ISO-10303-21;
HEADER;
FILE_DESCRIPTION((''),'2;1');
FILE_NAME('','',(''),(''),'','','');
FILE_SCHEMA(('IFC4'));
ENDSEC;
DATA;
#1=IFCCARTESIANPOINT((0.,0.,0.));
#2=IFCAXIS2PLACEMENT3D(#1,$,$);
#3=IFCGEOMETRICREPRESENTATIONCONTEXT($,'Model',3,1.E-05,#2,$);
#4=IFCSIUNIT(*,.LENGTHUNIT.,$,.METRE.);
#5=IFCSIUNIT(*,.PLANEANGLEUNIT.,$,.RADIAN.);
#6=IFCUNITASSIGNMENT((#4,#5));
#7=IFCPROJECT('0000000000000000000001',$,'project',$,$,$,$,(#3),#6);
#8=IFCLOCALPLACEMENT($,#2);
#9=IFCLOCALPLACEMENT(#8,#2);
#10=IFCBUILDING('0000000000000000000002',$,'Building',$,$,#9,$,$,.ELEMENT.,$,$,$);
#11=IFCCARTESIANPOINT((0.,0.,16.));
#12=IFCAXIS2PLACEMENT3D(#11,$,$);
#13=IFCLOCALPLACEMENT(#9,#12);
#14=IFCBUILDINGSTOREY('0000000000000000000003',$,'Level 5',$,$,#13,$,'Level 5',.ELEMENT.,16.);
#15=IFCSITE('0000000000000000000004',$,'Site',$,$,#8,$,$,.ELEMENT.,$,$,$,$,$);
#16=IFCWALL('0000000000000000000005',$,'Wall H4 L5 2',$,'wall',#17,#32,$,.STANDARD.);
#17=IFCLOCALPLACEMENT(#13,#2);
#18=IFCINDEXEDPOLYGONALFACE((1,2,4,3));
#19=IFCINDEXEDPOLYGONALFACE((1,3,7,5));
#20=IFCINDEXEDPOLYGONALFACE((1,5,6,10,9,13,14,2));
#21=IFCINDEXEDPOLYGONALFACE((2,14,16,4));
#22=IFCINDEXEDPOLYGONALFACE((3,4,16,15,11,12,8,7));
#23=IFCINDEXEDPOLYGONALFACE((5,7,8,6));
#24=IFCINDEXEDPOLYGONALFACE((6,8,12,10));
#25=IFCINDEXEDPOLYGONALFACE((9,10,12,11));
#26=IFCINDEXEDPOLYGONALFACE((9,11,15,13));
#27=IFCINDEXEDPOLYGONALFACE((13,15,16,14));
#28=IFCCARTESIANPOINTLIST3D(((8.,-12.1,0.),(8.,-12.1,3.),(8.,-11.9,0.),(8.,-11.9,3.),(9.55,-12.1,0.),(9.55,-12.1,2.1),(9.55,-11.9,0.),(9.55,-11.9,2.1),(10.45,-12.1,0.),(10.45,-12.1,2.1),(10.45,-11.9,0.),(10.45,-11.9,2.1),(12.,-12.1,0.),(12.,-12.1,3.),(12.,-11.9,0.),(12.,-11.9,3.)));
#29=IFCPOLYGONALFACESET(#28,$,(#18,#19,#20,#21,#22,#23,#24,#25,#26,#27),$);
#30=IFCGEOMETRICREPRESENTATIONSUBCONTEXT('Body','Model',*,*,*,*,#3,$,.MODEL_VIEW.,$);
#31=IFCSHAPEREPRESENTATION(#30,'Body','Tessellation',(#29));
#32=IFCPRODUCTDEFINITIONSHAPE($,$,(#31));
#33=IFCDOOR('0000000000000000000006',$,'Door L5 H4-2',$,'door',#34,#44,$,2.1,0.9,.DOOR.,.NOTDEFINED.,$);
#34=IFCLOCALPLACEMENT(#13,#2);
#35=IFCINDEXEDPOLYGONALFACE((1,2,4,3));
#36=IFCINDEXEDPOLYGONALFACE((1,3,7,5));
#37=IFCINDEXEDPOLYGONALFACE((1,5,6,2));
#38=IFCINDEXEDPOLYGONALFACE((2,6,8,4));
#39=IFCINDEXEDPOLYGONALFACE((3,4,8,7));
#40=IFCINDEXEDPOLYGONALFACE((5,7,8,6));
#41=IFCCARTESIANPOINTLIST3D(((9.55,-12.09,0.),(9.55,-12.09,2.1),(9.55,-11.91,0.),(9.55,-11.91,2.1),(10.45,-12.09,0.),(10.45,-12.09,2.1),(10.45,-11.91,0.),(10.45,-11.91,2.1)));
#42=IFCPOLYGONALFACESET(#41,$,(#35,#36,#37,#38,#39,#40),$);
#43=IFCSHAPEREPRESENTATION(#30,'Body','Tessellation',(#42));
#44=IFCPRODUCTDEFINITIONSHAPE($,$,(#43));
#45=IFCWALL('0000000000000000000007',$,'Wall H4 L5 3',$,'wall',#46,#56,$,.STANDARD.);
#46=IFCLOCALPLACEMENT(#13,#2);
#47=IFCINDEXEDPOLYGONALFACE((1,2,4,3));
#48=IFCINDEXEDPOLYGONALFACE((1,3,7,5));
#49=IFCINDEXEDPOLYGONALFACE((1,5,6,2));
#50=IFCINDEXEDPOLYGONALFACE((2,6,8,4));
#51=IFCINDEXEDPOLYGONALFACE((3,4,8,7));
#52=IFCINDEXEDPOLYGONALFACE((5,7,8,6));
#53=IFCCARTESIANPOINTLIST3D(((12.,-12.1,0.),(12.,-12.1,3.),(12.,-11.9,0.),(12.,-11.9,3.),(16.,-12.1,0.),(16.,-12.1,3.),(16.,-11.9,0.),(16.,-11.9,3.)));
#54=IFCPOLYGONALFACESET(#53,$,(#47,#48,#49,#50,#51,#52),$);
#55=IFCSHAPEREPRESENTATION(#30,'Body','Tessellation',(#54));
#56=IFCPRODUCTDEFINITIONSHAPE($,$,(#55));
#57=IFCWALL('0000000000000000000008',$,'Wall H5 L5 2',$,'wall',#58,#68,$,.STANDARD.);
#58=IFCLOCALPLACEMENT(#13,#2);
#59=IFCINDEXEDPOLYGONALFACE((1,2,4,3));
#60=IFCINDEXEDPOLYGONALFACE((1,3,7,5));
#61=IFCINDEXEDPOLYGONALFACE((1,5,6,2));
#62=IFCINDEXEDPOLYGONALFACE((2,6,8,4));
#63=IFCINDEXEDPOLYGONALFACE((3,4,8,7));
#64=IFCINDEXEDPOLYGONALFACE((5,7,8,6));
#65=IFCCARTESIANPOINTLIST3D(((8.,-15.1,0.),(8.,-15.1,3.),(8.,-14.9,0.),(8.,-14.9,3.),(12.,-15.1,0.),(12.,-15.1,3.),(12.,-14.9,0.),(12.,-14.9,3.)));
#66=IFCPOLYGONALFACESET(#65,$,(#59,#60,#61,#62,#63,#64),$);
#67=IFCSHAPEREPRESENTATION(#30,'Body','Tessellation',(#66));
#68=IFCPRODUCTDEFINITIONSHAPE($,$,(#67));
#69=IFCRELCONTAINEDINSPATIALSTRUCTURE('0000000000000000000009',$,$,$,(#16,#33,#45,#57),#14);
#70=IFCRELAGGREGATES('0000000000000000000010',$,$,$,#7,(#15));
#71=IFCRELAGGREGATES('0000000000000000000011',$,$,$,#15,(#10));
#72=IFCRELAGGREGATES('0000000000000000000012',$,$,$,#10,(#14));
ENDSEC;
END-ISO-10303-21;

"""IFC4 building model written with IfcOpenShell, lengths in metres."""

from ifc_helpers import new_model, si_unit, frame, frame_2d, origin, origin_2d, place, context, subcontext, project, spatial, rectangle, extrude, element, fill, save


model = new_model("IFC4")

# Units and contexts
model_context = context("Model", 3, precision=1e-05, world=origin())
body_context = subcontext(model_context, "Body", "Model", "MODEL_VIEW")
ifc_project = project(units=[si_unit("LENGTHUNIT", "METRE"), si_unit("PLANEANGLEUNIT", "RADIAN")], contexts=[model_context])

# Site, building, storey
site_placement = place(None, origin())
site = spatial("IfcSite", under=ifc_project, at=site_placement, Name="Site", CompositionType="ELEMENT")
building_placement = place(site_placement, origin())
building = spatial("IfcBuilding", under=site, at=building_placement, Name="Building", CompositionType="ELEMENT")
storey_placement = place(building_placement, frame((0.0, 0.0, 16.0)))
storey = spatial("IfcBuildingStorey", under=building, at=storey_placement, Name="Level 5", LongName="Level 5", CompositionType="ELEMENT", Elevation=16.0)

# Wall, opening, door
wall_1_placement = place(storey_placement, frame((8.0, -12.0, 0.0), z_axis=(0.0, 0.0, 1.0), x_axis=(1.0, 0.0, 0.0)))
wall_1 = element("IfcWall", 1, at=wall_1_placement, inside=storey, Name="Wall H4 L5 2", ObjectType="wall", PredefinedType="STANDARD", context=body_context, shape_type="SweptSolid", body=[
    extrude(rectangle(XDim=4.0, YDim=0.2, at=frame_2d((2.0, 0.0))), origin(), (0.0, 0.0, 1.0), 3.0),
])
opening_1_placement = place(storey_placement, frame((10.0, -12.0, 0.0), z_axis=(0.0, 0.0, 1.0), x_axis=(1.0, 0.0, 0.0)))
opening_1 = element("IfcOpeningElement", 2, at=opening_1_placement, cuts=wall_1, ObjectType="Opening", PredefinedType="OPENING", context=body_context, shape_type="SweptSolid", body=[
    extrude(rectangle(XDim=0.9, YDim=0.22, at=origin_2d()), origin(), (0.0, 0.0, 1.0), 2.1),
])
door_1_placement = place(storey_placement, frame((10.0, -12.0, 0.0), z_axis=(0.0, 0.0, 1.0), x_axis=(1.0, 0.0, 0.0)))
door_1 = element("IfcDoor", 3, at=door_1_placement, inside=storey, Name="Door L5 H4-2", ObjectType="door", OperationType="NOTDEFINED", OverallHeight=2.1, OverallWidth=0.9, PredefinedType="DOOR", context=body_context, shape_type="SweptSolid", body=[
    extrude(rectangle(XDim=0.9, YDim=0.18, at=origin_2d()), origin(), (0.0, 0.0, 1.0), 2.1),
])
fill(opening_1, door_1)

# Walls
for number, where, z_axis, x_axis, name in (
    (4, (12.0, -12.0, 0.0), (0.0, 0.0, 1.0), (1.0, 0.0, 0.0), "Wall H4 L5 3"),
    (5, (8.0, -15.0, 0.0), (0.0, 0.0, 1.0), (1.0, 0.0, 0.0), "Wall H5 L5 2"),
):
    element("IfcWall", number, at=place(storey_placement, frame(where, z_axis=z_axis, x_axis=x_axis)), inside=storey, Name=name, ObjectType="wall", PredefinedType="STANDARD", context=body_context, shape_type="SweptSolid", body=[
        extrude(rectangle(XDim=4.0, YDim=0.2, at=frame_2d((2.0, 0.0))), origin(), (0.0, 0.0, 1.0), 3.0),
    ])

save(model, "model.ifc")
